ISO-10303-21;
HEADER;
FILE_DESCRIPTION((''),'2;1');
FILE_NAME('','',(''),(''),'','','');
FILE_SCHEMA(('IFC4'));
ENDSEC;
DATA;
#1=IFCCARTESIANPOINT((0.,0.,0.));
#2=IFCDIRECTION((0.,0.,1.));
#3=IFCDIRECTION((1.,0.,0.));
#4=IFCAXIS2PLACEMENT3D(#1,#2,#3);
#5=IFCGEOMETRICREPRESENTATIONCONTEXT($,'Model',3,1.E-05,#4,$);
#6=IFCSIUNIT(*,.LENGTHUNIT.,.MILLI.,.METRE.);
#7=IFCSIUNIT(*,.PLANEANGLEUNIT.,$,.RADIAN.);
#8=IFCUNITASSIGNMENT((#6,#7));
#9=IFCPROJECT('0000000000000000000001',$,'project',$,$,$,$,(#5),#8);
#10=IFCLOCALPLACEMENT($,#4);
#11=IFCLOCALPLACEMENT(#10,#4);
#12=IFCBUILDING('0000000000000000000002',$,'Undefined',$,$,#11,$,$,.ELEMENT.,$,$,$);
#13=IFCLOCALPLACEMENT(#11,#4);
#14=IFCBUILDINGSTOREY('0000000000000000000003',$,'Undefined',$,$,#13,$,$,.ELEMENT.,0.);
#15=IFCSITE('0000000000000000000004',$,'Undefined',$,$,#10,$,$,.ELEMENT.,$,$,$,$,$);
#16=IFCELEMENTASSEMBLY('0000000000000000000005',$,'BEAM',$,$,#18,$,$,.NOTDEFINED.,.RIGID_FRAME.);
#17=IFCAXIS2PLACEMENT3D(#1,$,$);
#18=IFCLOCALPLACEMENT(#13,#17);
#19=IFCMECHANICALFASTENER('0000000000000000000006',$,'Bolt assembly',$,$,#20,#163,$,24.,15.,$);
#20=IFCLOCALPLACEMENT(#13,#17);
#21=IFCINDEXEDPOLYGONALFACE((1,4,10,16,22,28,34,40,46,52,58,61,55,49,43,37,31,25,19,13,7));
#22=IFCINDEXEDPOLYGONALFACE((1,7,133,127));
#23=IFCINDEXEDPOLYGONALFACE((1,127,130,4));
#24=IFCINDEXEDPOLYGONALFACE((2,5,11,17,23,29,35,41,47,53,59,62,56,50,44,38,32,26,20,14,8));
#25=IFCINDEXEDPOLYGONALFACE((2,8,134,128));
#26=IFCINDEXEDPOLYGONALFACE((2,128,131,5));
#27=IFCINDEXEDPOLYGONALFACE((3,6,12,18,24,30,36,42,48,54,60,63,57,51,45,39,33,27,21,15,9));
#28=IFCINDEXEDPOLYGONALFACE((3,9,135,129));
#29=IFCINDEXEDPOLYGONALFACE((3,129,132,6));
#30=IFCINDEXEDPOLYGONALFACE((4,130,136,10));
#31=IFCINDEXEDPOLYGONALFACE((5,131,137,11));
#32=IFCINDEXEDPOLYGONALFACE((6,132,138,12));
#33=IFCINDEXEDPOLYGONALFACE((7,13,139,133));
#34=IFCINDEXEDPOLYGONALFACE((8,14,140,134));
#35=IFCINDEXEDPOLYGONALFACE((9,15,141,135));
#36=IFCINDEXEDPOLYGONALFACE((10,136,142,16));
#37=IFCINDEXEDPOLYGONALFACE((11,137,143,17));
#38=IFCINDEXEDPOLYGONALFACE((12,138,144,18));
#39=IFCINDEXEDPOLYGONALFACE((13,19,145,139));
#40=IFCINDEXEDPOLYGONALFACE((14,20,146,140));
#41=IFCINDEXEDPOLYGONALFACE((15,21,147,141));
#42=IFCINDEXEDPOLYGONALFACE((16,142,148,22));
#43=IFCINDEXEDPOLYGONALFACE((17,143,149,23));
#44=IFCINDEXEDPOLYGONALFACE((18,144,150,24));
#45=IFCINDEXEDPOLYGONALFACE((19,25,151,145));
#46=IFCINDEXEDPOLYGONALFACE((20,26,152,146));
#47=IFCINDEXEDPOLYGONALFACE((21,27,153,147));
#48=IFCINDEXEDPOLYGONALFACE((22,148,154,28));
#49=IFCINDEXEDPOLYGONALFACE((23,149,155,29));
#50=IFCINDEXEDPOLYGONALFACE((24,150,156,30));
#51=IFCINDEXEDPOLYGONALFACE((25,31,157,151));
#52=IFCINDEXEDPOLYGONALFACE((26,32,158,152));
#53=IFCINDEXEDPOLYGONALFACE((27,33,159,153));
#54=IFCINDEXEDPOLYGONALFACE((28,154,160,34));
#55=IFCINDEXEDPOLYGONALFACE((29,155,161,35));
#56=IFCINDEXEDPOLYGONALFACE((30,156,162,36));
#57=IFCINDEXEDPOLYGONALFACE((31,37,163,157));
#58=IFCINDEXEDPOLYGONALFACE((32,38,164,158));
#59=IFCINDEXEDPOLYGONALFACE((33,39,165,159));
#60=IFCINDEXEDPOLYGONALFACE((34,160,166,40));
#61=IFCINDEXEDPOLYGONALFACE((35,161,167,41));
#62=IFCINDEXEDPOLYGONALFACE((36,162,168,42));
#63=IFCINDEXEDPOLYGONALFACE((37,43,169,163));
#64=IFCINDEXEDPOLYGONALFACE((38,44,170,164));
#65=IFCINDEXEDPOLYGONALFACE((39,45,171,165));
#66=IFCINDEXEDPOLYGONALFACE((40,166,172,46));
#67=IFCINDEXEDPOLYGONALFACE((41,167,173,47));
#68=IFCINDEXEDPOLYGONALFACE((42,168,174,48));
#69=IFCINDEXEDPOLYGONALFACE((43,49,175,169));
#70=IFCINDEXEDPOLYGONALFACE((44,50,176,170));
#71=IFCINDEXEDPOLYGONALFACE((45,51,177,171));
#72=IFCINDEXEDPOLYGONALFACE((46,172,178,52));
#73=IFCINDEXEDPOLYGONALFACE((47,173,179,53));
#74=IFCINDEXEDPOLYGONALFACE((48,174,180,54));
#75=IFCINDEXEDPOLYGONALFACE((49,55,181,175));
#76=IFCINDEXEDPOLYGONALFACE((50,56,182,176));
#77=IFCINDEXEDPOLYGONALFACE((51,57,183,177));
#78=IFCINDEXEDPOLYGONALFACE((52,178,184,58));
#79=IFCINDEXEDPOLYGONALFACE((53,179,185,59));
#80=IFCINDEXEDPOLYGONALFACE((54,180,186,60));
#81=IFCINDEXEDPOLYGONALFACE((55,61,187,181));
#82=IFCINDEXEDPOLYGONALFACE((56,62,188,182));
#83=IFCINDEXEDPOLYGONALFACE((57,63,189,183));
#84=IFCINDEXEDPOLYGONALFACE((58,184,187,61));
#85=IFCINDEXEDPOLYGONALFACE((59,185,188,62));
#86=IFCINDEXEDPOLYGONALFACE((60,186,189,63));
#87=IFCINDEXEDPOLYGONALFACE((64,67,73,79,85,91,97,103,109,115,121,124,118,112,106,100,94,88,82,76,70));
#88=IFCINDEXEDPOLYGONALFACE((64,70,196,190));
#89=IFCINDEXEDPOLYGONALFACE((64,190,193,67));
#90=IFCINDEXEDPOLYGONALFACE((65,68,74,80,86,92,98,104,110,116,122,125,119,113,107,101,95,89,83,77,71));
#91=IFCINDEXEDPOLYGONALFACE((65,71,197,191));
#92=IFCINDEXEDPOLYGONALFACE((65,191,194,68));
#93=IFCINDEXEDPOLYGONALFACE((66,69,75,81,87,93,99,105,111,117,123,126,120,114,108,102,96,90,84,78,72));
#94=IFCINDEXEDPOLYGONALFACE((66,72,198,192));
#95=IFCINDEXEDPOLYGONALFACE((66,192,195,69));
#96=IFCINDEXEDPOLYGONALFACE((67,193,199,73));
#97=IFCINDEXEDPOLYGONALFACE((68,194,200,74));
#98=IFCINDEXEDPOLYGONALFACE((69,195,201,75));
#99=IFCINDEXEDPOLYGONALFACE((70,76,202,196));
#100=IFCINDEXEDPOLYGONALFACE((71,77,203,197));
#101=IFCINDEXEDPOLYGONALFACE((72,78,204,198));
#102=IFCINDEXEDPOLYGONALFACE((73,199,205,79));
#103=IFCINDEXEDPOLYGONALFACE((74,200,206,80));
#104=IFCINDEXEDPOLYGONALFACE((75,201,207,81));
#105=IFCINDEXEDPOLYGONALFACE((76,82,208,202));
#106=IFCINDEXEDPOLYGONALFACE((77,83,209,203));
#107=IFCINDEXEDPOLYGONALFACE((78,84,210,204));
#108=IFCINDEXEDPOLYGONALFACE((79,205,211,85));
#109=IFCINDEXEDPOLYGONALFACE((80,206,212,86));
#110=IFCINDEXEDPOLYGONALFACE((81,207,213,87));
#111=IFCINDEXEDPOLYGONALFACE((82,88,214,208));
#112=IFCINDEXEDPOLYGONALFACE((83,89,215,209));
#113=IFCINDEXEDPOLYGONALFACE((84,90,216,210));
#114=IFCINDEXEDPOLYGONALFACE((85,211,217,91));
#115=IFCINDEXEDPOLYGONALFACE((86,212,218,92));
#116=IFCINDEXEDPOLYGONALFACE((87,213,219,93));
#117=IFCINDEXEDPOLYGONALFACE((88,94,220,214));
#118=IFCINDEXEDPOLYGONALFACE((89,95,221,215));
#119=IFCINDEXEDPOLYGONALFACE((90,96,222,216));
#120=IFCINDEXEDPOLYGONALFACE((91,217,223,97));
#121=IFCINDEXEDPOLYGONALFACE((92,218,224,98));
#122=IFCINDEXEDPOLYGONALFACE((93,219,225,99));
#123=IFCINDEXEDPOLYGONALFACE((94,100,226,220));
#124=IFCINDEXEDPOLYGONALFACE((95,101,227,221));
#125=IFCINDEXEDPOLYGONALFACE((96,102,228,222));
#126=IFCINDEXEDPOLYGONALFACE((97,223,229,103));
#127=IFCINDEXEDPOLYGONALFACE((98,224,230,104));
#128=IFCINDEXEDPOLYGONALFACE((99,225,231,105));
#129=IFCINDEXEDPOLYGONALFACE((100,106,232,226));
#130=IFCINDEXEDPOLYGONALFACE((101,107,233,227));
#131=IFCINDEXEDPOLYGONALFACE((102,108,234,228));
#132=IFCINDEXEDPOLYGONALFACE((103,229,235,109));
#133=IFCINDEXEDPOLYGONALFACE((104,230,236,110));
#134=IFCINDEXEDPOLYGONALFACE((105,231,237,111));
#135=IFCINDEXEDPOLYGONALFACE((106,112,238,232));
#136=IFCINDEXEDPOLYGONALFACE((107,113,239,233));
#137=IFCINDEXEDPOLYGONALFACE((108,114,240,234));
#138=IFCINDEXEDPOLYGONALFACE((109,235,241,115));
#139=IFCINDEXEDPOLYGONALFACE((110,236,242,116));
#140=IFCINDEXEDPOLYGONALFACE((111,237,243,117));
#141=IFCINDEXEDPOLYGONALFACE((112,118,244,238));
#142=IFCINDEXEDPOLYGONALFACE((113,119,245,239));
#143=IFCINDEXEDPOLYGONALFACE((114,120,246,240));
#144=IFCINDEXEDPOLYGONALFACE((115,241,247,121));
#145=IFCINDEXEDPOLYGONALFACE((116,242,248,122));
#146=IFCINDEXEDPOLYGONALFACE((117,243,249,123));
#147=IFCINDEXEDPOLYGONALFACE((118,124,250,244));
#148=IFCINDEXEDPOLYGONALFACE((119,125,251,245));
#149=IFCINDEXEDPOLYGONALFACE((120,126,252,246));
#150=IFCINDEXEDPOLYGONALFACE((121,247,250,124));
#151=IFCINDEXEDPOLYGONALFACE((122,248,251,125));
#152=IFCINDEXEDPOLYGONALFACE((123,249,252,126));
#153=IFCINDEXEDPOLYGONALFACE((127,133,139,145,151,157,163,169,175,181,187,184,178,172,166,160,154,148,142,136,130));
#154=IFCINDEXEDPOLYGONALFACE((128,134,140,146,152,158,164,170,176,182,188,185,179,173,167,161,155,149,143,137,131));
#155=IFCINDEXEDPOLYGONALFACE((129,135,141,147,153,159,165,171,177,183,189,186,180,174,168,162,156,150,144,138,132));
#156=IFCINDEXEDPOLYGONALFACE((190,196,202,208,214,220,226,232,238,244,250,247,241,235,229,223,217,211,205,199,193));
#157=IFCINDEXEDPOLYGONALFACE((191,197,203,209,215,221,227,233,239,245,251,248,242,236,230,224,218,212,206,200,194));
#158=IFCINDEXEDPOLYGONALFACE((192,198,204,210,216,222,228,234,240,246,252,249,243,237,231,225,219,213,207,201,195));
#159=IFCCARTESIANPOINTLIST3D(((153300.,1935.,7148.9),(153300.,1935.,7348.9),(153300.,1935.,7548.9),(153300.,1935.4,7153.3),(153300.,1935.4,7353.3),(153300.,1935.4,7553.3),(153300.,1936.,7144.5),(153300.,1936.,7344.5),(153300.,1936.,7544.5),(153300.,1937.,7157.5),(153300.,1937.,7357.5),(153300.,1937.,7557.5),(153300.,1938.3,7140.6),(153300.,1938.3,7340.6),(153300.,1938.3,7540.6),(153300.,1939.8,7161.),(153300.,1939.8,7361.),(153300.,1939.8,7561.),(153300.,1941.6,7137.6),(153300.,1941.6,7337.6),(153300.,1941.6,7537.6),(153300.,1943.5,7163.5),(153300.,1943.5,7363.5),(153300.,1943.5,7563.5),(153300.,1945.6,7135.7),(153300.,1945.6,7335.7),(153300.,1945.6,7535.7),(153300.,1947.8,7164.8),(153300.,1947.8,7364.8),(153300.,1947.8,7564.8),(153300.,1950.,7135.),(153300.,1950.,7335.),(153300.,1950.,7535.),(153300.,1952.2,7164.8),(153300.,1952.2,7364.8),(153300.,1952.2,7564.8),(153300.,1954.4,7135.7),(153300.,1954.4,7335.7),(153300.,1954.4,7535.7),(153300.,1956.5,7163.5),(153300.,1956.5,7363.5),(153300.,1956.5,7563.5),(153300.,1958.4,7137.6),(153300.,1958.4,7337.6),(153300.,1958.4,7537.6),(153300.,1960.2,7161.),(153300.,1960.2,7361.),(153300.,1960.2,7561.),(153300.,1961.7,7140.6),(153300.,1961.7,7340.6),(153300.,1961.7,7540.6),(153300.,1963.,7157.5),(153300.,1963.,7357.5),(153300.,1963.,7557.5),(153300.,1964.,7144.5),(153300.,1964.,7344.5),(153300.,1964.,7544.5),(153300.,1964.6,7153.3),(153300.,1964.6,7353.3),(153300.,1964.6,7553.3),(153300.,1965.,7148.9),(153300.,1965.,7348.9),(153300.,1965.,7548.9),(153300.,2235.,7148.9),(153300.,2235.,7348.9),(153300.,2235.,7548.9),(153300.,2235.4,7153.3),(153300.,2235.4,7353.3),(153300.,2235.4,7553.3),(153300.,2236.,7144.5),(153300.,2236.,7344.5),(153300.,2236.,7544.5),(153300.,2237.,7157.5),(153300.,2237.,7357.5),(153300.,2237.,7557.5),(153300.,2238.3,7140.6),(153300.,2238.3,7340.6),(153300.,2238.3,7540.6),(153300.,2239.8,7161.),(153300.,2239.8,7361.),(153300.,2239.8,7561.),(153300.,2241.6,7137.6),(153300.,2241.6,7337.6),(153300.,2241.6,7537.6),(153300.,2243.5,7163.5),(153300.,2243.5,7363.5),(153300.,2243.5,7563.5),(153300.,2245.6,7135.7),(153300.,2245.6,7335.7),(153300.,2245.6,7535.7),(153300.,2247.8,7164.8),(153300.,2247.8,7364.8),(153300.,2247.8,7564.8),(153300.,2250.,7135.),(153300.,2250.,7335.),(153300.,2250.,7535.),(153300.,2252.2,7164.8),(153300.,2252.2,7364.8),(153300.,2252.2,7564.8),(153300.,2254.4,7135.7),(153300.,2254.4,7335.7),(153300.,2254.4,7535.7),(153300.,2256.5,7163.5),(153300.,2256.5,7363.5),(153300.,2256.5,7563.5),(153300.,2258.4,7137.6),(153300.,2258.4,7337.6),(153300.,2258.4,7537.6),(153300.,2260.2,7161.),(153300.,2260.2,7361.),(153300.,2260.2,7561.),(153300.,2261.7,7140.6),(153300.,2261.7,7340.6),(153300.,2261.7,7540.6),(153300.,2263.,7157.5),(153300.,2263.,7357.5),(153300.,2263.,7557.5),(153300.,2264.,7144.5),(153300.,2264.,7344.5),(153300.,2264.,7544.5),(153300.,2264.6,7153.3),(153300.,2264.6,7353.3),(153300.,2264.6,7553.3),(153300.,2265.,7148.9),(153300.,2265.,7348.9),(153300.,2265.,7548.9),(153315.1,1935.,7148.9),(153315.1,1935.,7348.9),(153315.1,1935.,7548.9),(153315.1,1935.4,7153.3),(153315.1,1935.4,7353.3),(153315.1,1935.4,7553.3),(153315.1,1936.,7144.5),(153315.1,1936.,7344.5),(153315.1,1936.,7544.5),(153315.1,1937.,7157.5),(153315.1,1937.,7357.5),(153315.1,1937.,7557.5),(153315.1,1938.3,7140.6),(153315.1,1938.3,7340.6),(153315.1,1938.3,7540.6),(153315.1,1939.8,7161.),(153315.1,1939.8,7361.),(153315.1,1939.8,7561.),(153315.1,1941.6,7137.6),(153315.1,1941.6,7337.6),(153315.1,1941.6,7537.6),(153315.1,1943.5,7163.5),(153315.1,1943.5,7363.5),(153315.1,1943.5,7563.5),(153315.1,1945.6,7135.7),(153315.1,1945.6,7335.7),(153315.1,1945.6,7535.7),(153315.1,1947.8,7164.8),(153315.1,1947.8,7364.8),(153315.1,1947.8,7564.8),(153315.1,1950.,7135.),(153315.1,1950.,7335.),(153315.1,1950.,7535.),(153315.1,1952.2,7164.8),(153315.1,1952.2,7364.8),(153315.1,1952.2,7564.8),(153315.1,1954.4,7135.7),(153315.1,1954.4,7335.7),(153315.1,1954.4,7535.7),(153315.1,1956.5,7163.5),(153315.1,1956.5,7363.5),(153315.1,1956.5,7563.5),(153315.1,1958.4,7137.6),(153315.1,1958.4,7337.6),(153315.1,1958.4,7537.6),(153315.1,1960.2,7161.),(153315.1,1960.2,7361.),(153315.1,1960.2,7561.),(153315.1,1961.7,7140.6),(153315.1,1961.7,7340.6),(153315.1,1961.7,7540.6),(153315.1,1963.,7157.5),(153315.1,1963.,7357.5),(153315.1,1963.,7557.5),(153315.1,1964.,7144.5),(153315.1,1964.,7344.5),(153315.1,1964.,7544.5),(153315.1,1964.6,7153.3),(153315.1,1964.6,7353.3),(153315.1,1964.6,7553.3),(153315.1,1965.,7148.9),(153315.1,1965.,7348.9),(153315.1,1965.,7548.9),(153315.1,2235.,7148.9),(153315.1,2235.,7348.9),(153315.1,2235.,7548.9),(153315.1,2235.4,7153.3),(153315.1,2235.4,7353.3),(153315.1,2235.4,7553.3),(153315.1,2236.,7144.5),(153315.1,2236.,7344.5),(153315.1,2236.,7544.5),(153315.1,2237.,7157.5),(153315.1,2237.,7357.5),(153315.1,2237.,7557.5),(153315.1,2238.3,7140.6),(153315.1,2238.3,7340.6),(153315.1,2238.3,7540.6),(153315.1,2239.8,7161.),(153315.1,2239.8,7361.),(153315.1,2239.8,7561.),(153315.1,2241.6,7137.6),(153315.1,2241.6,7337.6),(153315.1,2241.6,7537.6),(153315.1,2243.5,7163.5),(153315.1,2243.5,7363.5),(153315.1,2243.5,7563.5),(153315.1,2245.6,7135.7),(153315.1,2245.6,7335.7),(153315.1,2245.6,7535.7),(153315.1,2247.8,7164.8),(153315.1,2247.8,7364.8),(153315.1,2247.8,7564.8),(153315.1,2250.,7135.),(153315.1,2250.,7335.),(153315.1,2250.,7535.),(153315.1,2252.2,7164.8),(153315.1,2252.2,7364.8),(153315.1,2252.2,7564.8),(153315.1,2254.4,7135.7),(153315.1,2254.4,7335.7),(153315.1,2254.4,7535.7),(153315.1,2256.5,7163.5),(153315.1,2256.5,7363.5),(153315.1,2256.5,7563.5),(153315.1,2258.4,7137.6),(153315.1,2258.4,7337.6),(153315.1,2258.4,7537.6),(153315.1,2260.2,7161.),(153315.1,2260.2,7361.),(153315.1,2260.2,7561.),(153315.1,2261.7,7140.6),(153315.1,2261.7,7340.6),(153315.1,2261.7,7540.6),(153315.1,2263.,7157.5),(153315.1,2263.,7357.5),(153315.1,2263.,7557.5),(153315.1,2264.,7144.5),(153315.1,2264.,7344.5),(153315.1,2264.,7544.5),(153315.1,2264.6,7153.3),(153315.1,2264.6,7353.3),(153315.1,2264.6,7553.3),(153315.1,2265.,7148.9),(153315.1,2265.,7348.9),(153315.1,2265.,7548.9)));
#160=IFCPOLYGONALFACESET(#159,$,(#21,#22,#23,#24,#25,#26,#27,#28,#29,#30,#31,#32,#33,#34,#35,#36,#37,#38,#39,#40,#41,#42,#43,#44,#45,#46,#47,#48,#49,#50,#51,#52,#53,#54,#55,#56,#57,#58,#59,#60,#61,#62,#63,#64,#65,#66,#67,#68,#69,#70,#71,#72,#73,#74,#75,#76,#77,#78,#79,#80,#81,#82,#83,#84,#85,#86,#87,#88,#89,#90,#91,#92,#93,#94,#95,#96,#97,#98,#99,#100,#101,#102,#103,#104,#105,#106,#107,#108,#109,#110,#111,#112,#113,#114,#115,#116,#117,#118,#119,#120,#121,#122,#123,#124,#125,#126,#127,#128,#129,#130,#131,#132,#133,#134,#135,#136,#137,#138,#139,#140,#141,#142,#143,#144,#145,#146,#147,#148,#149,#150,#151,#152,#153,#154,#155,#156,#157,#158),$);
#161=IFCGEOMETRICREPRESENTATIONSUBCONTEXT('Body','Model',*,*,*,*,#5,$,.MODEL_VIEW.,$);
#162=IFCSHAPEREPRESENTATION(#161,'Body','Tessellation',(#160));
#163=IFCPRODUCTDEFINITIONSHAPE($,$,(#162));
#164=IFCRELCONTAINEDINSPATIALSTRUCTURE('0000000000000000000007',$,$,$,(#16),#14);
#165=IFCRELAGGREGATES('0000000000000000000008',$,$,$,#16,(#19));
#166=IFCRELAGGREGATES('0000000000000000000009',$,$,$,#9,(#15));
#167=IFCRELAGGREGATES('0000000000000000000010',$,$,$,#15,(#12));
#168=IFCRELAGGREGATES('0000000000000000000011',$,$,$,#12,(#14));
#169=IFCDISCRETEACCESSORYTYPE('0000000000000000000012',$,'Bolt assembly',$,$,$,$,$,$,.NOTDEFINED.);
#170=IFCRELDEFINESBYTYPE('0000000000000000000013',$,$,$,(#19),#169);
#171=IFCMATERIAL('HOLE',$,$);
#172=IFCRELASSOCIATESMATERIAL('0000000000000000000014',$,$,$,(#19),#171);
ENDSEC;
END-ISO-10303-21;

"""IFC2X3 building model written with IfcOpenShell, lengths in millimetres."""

from ifc_helpers import new_model, si_unit, frame, origin_with_axes, origin_2d_with_axis, place, context, subcontext, project, spatial, circle, extrude, source, transform, mapped, material, type_object, element, aggregate, save


model = new_model("IFC2X3")

# Units and contexts
model_context = context("Model", 3, precision=1e-05, world=origin_with_axes())
body_context = subcontext(model_context, "Body", "Model", "MODEL_VIEW")
ifc_project = project(units=[si_unit("LENGTHUNIT", "METRE", prefix="MILLI"), si_unit("PLANEANGLEUNIT", "RADIAN")], contexts=[model_context])

# Site, building, storey
site_placement = place(None, origin_with_axes())
site = spatial("IfcSite", under=ifc_project, at=site_placement, Name="Undefined", CompositionType="ELEMENT")
building_placement = place(site_placement, origin_with_axes())
building = spatial("IfcBuilding", under=site, at=building_placement, Name="Undefined", CompositionType="ELEMENT")
storey_placement = place(building_placement, origin_with_axes())
storey = spatial("IfcBuildingStorey", under=building, at=storey_placement, Name="Undefined", CompositionType="ELEMENT", Elevation=0.0)

# Element assembly
assembly_1_placement = place(storey_placement, origin_with_axes())
assembly_1 = element("IfcElementAssembly", 1, at=assembly_1_placement, inside=storey, Name="BEAM", AssemblyPlace="NOTDEFINED", PredefinedType="RIGID_FRAME")

# Mechanical fastener
ifc_material_1 = material(Name="HOLE")
discrete_accessory_type_1 = type_object("IfcDiscreteAccessoryType", Name="Bolt assembly")
shared_shape_1 = source(origin_with_axes(), body_context, "Body", "SweptSolid", [
    extrude(circle(Radius=15.0, at=origin_2d_with_axis()), frame((0.0, -15.0, 0.0), z_axis=(0.0, 1.0, 0.0), x_axis=(1.0, 0.0, 0.0)), (0.0, 0.0, 1.0), 15.1),
])
mechanical_fastener_1_placement = place(assembly_1_placement, frame((153315.0, 2100.0, 7550.0), z_axis=(0.0, -1.0, 0.0), x_axis=(0.0, 0.0, -1.0)))
mechanical_fastener_1 = element("IfcMechanicalFastener", 2, at=mechanical_fastener_1_placement, type_object=discrete_accessory_type_1, material=ifc_material_1, Name="Bolt assembly", NominalDiameter=24.0, NominalLength=15.0, context=body_context, shape_type="MappedRepresentation", body=[
    mapped(shared_shape_1, transform((0.0, 0.0, -150.0))),
    mapped(shared_shape_1, transform((0.0, 0.0, 150.0))),
    mapped(shared_shape_1, transform((200.0, 0.0, -150.0))),
    mapped(shared_shape_1, transform((200.0, 0.0, 150.0))),
    mapped(shared_shape_1, transform((400.0, 0.0, -150.0))),
    mapped(shared_shape_1, transform((400.0, 0.0, 150.0))),
])
aggregate(assembly_1, [mechanical_fastener_1])

save(model, "model.ifc")
